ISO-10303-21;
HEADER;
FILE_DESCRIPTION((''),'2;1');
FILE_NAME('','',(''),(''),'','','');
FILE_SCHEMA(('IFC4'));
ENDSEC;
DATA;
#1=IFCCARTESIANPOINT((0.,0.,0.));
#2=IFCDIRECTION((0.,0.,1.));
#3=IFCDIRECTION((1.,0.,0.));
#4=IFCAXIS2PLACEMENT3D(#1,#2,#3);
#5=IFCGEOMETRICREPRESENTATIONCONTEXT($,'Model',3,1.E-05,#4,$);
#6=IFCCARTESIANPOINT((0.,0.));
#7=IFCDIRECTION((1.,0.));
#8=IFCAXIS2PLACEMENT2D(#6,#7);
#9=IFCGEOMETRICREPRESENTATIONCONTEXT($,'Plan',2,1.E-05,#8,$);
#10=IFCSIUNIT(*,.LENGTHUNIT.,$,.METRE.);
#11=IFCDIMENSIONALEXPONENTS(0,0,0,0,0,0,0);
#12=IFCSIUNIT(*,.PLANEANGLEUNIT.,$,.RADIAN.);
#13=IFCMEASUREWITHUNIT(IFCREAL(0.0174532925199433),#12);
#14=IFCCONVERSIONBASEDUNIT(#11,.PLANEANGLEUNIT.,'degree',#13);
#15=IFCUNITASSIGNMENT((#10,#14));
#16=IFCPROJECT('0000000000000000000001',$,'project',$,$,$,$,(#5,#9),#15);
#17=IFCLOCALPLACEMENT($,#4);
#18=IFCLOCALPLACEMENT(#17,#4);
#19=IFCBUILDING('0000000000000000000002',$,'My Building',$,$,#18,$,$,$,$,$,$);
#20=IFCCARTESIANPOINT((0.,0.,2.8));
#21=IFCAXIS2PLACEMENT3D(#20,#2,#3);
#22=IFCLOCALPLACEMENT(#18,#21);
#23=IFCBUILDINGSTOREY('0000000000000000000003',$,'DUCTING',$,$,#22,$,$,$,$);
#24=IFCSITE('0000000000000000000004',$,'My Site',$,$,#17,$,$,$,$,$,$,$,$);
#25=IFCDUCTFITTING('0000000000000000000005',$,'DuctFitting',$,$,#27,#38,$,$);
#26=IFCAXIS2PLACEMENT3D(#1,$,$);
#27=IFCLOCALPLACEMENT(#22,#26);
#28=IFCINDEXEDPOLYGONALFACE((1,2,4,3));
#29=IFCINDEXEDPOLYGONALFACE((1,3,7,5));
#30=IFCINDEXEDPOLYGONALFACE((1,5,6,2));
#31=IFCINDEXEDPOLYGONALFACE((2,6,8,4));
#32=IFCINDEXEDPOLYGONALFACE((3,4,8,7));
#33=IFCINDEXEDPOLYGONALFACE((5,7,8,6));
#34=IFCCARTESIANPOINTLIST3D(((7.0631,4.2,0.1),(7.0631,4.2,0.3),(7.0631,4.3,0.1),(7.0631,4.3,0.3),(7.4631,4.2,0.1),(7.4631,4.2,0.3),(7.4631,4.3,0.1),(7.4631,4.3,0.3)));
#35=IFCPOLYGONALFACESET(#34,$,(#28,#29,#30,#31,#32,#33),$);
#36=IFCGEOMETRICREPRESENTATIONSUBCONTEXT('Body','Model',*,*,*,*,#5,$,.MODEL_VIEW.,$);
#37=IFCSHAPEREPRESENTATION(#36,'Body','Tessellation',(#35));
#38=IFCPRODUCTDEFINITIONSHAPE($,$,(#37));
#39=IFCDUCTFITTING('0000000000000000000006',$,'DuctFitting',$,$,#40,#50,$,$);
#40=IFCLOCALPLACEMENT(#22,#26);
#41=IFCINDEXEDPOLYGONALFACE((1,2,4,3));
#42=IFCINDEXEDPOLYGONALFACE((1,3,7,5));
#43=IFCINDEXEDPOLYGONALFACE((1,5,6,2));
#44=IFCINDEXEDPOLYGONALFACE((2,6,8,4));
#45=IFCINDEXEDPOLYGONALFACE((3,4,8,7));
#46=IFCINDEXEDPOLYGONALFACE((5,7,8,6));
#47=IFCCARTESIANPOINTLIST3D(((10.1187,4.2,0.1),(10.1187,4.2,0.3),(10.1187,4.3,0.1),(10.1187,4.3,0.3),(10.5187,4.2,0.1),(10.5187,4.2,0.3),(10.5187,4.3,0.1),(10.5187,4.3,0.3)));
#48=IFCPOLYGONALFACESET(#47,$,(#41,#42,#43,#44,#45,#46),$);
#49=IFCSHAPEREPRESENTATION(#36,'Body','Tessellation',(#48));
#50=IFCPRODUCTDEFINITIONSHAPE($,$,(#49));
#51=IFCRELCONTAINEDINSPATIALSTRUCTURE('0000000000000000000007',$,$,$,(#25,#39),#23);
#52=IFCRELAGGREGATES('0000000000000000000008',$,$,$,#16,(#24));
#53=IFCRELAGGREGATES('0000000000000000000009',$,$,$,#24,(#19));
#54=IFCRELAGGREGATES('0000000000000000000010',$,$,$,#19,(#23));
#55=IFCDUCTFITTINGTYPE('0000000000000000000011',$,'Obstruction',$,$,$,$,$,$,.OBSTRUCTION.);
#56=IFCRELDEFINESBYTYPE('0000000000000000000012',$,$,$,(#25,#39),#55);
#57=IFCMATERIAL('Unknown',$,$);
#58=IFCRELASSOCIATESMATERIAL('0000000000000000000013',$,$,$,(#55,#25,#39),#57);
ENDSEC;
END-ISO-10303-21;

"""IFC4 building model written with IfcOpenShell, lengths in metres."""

from ifc_helpers import new_model, entity, si_unit, converted_unit, frame, origin_with_axes, origin_2d_with_axis, place, context, subcontext, project, spatial, rectangle, extrude, material, material_profile, profile_set, profile_usage, type_object, element, save


model = new_model("IFC4")

# Units and contexts
model_context = context("Model", 3, precision=1e-05, world=origin_with_axes())
plan_context = context("Plan", 2, precision=1e-05, world=origin_2d_with_axis())
body_context = subcontext(model_context, "Body", "Model", "MODEL_VIEW")
ifc_project = project(units=[si_unit("LENGTHUNIT", "METRE"), converted_unit("PLANEANGLEUNIT", "degree", entity("IfcReal", 0.0174532925199433), si_unit("PLANEANGLEUNIT", "RADIAN"), dimensions=[0, 0, 0, 0, 0, 0, 0])], contexts=[model_context, plan_context])

# Site, building, storey
site_placement = place(None, origin_with_axes())
site = spatial("IfcSite", under=ifc_project, at=site_placement, Name="My Site")
building_placement = place(site_placement, origin_with_axes())
building = spatial("IfcBuilding", under=site, at=building_placement, Name="My Building")
storey_placement = place(building_placement, frame((0.0, 0.0, 2.8), z_axis=(0.0, 0.0, 1.0), x_axis=(1.0, 0.0, 0.0)))
storey = spatial("IfcBuildingStorey", under=building, at=storey_placement, Name="DUCTING")

# Shared definitions
ifc_material = material(Name="Unknown")

# Duct fittings
ifc_material_profile_1 = material_profile(ifc_material, rectangle(XDim=0.4, YDim=0.2))
ifc_profile_set_1 = profile_set([ifc_material_profile_1])
duct_fitting_type_1 = type_object("IfcDuctFittingType", Name="Obstruction", PredefinedType="OBSTRUCTION", material=ifc_profile_set_1)
ifc_profile_usage_1 = profile_usage(ifc_profile_set_1, cardinal=5)
duct_fitting_1_placement = place(storey_placement, frame((7.2631, 4.3, 0.2), z_axis=(0.0, -1.0, 0.0), x_axis=(1.0, 0.0, 0.0)))
element("IfcDuctFitting", 1, at=duct_fitting_1_placement, inside=storey, type_object=duct_fitting_type_1, material=ifc_profile_usage_1, Name="DuctFitting", context=body_context, shape_type="SweptSolid", body=[
    extrude(rectangle(XDim=0.4, YDim=0.2), origin_with_axes(), (0.0, 0.0, 1.0), 0.1),
])
ifc_profile_usage_2 = profile_usage(ifc_profile_set_1, cardinal=5)
duct_fitting_2_placement = place(storey_placement, frame((10.3187, 4.3, 0.2), z_axis=(0.0, -1.0, 0.0), x_axis=(1.0, 0.0, 0.0)))
element("IfcDuctFitting", 2, at=duct_fitting_2_placement, inside=storey, type_object=duct_fitting_type_1, material=ifc_profile_usage_2, Name="DuctFitting", context=body_context, shape_type="SweptSolid", body=[
    extrude(rectangle(XDim=0.4, YDim=0.2), origin_with_axes(), (0.0, 0.0, 1.0), 0.1),
])

save(model, "model.ifc")
